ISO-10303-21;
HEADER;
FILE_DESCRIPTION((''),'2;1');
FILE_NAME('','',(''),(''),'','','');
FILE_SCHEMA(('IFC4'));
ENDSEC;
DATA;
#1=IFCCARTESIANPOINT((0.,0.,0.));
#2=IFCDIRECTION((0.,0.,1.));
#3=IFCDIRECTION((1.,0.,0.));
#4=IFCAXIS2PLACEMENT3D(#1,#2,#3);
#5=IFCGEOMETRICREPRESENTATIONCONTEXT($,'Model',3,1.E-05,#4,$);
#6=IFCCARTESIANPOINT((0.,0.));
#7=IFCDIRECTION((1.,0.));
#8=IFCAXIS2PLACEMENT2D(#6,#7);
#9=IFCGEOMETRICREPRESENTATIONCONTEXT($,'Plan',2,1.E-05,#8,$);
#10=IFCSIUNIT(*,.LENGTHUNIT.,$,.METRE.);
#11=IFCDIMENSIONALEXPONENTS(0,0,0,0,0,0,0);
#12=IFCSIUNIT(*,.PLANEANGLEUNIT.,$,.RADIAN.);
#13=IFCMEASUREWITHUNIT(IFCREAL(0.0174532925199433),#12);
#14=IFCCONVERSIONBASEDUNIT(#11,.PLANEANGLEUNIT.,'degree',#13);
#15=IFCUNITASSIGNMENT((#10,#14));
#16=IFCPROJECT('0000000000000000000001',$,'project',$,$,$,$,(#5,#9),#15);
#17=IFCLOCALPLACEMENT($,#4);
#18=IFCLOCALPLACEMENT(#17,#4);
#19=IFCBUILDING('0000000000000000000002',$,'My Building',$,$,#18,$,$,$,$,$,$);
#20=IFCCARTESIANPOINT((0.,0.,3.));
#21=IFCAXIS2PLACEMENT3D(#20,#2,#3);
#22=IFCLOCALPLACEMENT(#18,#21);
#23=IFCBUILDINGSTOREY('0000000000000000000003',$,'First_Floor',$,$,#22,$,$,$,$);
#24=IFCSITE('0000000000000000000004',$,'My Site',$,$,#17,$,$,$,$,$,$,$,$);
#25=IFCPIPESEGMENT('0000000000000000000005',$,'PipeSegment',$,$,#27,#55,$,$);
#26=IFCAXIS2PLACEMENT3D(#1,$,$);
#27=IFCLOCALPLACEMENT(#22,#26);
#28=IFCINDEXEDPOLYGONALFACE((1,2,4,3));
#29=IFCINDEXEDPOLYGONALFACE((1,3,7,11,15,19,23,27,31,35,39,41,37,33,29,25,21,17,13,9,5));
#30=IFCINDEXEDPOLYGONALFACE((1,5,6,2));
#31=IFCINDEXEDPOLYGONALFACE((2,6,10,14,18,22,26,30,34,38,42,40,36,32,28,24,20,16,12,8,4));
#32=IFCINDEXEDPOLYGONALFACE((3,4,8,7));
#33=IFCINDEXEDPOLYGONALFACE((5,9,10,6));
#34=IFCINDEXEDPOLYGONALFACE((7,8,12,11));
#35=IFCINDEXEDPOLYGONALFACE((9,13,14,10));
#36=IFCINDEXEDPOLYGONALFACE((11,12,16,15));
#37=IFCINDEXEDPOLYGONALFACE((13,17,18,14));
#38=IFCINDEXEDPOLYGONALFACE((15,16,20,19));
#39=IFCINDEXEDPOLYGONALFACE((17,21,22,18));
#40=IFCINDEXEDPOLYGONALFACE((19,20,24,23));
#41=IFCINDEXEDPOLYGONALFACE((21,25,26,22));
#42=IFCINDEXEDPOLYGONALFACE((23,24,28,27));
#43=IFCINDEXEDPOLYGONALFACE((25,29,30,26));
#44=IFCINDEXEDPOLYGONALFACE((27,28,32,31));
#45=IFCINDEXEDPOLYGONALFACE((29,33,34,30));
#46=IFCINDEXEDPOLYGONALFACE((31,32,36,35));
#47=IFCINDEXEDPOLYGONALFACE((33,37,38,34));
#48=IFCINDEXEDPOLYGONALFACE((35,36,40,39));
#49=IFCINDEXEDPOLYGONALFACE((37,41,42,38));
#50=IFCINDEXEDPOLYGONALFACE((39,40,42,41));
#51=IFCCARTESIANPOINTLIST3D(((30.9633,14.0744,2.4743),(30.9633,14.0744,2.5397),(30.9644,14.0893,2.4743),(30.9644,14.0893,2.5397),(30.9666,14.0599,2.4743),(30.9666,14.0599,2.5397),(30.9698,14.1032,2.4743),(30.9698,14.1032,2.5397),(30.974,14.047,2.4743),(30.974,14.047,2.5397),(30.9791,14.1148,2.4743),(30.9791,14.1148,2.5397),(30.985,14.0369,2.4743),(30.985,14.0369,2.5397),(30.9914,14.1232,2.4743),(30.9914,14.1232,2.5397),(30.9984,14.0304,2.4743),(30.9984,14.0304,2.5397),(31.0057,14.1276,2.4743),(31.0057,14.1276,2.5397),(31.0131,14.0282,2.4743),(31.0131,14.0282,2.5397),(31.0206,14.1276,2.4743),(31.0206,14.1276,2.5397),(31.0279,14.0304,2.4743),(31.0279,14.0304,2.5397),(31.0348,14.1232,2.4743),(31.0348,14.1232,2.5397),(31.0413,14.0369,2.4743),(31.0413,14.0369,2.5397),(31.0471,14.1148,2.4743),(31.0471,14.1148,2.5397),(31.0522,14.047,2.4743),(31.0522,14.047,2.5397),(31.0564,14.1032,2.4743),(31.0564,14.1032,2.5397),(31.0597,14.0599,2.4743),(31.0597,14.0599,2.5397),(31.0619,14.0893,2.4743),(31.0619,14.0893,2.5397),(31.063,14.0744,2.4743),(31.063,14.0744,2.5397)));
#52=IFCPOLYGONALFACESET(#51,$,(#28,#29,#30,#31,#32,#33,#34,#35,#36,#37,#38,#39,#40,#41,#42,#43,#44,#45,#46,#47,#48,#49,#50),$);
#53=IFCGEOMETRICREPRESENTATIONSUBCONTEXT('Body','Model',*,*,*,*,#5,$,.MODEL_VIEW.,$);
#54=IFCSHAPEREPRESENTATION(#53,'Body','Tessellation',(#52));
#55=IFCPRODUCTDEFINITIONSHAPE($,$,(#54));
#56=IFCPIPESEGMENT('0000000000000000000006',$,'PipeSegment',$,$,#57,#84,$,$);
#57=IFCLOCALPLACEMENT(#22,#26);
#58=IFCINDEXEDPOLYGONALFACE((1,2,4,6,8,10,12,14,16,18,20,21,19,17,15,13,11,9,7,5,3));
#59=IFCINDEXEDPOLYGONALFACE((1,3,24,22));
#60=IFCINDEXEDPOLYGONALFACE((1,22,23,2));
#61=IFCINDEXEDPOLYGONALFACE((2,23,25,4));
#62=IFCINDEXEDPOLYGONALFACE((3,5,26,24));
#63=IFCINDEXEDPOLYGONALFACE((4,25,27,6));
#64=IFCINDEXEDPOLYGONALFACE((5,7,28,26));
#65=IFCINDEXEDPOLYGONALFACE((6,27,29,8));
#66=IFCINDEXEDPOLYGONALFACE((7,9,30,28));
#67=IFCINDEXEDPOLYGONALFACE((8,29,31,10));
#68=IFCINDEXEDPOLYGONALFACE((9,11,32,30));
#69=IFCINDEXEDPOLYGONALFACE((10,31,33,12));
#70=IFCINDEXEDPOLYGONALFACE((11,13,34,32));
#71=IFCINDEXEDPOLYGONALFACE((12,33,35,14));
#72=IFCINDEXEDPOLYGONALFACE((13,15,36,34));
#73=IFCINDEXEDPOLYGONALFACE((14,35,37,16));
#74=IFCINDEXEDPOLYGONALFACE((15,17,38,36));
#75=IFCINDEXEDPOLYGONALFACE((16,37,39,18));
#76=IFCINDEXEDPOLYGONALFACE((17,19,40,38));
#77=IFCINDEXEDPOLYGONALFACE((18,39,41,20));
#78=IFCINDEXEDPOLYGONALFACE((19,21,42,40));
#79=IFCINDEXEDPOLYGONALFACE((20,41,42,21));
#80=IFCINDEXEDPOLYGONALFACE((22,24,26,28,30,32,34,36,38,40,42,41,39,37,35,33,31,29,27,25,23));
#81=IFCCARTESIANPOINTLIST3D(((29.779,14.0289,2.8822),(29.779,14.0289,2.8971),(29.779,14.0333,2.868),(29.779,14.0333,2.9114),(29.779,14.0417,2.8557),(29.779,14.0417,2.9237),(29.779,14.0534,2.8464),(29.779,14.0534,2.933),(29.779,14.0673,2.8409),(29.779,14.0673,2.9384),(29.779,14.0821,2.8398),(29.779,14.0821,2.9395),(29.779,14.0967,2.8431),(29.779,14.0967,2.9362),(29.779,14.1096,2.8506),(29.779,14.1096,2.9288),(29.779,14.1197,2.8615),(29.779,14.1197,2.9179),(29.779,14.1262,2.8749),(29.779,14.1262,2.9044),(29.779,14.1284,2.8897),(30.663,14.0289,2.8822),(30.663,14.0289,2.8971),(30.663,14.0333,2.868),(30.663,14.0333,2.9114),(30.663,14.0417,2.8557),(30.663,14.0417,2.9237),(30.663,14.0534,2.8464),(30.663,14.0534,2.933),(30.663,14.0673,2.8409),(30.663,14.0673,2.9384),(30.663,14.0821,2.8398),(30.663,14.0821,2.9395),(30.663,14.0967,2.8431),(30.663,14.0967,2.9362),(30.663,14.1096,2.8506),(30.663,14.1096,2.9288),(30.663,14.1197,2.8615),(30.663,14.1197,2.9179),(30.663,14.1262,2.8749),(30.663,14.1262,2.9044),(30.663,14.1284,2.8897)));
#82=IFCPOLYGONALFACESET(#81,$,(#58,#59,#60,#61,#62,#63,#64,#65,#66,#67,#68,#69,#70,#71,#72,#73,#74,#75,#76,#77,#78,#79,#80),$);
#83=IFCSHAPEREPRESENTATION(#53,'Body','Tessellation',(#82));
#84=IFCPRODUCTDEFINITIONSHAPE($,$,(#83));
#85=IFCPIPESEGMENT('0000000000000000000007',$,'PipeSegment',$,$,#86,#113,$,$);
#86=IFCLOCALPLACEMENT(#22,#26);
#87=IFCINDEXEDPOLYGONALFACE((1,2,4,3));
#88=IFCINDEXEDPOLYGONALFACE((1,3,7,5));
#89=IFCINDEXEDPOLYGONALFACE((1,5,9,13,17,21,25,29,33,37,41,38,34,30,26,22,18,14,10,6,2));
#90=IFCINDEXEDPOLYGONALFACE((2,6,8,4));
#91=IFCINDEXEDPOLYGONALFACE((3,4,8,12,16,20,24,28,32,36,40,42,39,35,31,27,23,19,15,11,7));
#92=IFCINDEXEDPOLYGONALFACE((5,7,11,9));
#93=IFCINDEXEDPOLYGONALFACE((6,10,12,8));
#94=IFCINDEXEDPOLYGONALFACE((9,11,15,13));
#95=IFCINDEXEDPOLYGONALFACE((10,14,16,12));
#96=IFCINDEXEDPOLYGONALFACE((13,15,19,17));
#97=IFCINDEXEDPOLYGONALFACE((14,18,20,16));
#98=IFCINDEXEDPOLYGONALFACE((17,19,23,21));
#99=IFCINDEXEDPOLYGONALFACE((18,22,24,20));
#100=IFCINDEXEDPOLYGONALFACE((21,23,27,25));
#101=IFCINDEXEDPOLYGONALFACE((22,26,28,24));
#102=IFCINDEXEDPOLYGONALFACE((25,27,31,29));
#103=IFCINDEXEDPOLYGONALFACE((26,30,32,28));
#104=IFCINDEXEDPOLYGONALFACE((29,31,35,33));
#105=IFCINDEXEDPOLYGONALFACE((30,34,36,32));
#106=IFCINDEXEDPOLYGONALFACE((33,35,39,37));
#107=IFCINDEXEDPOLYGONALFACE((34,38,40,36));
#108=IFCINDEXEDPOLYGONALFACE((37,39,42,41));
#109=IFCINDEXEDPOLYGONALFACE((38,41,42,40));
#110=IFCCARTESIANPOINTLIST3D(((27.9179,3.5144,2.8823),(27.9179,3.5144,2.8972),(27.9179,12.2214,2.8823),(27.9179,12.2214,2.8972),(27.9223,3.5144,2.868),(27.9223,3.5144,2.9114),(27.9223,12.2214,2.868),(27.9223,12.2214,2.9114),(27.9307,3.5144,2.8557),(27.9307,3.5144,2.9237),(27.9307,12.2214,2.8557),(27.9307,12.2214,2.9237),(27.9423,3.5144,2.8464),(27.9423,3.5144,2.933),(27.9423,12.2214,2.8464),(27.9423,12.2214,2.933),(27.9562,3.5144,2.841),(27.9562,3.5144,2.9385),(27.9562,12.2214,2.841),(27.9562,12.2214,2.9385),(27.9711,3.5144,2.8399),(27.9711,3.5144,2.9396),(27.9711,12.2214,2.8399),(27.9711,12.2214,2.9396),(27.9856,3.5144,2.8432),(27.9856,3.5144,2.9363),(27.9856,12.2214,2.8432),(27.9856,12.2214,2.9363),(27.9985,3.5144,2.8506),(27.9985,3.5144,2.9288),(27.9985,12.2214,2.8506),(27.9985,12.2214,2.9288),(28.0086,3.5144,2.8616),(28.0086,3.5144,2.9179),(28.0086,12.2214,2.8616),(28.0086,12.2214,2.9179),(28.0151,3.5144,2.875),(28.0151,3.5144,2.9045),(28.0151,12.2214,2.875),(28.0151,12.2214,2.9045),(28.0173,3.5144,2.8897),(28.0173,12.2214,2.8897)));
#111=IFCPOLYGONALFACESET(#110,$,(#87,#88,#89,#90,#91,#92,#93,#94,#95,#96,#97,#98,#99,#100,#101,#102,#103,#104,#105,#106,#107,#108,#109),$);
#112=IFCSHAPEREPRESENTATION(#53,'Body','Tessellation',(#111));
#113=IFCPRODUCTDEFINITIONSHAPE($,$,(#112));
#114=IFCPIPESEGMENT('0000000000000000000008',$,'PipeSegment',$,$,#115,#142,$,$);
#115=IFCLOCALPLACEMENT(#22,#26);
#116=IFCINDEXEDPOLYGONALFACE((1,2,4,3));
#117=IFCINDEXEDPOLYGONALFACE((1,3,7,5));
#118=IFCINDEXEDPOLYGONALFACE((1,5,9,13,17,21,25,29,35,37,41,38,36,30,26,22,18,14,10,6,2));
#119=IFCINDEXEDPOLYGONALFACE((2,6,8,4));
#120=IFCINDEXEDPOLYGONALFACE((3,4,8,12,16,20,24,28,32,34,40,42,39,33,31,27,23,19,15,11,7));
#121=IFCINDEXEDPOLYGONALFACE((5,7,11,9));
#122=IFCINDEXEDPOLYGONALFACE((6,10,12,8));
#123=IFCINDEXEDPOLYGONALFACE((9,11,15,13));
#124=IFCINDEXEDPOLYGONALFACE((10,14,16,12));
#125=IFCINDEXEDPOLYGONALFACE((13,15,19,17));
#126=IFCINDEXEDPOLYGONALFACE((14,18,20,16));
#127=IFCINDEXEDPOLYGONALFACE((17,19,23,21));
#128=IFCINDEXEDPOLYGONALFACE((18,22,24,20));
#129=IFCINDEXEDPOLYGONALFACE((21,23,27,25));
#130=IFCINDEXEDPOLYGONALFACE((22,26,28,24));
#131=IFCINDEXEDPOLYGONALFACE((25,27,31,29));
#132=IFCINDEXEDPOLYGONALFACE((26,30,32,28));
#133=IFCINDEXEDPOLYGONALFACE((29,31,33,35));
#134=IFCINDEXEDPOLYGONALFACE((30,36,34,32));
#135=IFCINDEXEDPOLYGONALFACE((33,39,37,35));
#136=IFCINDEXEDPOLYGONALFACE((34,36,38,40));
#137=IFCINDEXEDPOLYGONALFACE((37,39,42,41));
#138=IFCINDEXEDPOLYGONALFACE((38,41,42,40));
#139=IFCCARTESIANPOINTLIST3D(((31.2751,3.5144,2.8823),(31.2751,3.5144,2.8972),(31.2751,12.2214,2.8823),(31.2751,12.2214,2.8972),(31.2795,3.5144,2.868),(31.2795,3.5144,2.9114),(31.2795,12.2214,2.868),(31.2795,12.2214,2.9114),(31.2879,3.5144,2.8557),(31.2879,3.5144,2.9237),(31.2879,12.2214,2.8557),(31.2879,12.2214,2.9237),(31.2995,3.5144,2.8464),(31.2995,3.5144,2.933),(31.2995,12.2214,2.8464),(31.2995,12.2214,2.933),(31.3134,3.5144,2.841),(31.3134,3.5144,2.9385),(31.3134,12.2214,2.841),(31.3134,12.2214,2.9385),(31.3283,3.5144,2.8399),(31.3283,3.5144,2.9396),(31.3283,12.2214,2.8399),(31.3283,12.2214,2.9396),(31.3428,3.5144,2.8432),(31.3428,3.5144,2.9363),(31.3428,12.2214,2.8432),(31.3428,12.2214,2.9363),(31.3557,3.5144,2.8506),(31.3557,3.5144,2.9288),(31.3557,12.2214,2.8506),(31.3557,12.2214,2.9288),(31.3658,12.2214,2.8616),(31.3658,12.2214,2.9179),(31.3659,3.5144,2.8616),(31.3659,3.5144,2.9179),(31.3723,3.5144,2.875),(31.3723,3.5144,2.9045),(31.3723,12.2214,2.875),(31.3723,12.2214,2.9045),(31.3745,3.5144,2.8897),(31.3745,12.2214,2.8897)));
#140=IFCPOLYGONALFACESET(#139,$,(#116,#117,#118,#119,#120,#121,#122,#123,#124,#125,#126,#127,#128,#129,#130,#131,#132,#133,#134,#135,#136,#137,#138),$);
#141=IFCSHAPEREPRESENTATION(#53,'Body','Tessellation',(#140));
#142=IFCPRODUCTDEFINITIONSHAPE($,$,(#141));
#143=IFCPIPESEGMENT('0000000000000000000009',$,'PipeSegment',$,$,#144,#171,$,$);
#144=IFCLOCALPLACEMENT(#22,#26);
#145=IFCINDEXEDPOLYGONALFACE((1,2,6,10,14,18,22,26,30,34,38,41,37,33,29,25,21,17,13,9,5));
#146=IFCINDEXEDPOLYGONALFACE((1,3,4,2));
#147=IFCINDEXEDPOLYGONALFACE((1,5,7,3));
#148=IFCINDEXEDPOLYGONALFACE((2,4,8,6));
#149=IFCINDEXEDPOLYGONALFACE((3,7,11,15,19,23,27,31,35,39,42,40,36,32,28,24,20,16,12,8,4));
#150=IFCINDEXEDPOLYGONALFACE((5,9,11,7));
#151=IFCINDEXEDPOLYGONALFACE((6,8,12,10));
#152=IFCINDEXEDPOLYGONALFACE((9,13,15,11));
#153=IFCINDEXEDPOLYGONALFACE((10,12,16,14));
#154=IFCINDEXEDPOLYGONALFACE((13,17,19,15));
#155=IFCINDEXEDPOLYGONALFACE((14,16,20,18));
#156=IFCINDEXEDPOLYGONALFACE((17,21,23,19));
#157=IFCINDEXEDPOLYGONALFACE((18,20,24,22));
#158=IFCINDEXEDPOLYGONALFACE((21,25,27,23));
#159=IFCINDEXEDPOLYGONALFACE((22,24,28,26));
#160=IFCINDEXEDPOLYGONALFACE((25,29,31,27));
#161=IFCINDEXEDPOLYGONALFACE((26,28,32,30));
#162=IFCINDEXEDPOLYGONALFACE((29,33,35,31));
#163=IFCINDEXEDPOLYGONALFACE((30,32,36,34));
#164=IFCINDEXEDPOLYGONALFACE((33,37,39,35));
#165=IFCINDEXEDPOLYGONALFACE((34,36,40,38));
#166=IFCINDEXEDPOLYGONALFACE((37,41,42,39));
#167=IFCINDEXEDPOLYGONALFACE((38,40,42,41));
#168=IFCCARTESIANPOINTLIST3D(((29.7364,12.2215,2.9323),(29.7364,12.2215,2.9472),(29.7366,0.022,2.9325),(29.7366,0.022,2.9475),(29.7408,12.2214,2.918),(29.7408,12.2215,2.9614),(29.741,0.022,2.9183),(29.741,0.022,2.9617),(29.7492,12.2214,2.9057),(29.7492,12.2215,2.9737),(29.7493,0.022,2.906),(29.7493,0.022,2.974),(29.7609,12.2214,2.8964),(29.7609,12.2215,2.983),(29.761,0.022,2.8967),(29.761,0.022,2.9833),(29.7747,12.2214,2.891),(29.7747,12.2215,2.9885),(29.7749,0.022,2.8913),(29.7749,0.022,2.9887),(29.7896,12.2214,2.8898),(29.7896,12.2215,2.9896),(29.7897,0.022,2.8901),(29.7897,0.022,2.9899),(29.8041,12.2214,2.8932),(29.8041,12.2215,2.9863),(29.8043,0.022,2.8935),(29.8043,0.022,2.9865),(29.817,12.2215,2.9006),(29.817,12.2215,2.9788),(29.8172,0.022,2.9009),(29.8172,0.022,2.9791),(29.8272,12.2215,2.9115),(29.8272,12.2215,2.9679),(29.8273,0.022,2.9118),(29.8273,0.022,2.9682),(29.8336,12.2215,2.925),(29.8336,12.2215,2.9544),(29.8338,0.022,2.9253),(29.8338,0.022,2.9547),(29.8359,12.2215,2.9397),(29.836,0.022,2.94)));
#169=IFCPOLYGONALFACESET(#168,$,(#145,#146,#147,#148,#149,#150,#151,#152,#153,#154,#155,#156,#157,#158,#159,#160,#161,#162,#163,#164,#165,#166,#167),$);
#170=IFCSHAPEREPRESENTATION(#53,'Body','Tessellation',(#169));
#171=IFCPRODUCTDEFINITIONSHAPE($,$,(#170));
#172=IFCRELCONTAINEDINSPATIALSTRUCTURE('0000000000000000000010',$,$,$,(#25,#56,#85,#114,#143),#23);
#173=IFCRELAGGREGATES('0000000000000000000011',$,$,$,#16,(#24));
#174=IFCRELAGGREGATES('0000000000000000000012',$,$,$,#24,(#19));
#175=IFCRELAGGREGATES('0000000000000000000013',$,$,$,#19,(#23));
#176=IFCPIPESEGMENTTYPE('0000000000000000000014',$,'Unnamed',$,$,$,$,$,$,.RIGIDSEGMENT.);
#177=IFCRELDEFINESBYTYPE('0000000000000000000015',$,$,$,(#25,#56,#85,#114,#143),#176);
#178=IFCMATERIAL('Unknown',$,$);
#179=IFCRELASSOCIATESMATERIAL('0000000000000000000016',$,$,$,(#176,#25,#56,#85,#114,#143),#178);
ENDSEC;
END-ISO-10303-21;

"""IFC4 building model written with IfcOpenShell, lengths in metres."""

from ifc_helpers import new_model, entity, si_unit, converted_unit, frame, origin_with_axes, origin_2d_with_axis, place, context, subcontext, project, spatial, circle, extrude, material, material_profile, profile_set, profile_usage, type_object, element, save


model = new_model("IFC4")

# Units and contexts
model_context = context("Model", 3, precision=1e-05, world=origin_with_axes())
plan_context = context("Plan", 2, precision=1e-05, world=origin_2d_with_axis())
body_context_1 = subcontext(model_context, "Body", "Model", "MODEL_VIEW")
ifc_project = project(units=[si_unit("LENGTHUNIT", "METRE"), converted_unit("PLANEANGLEUNIT", "degree", entity("IfcReal", 0.0174532925199433), si_unit("PLANEANGLEUNIT", "RADIAN"), dimensions=[0, 0, 0, 0, 0, 0, 0])], contexts=[model_context, plan_context])

# Site, building, storey
site_placement = place(None, origin_with_axes())
site = spatial("IfcSite", under=ifc_project, at=site_placement, Name="My Site")
building_placement = place(site_placement, origin_with_axes())
building = spatial("IfcBuilding", under=site, at=building_placement, Name="My Building")
storey_placement = place(building_placement, frame((0.0, 0.0, 3.0), z_axis=(0.0, 0.0, 1.0), x_axis=(1.0, 0.0, 0.0)))
storey = spatial("IfcBuildingStorey", under=building, at=storey_placement, Name="First_Floor")

# Shared definitions
ifc_material = material(Name="Unknown")

# Pipe segments
ifc_material_profile_1 = material_profile(ifc_material, circle(Radius=0.05))
ifc_profile_set_1 = profile_set([ifc_material_profile_1])
pipe_segment_type = type_object("IfcPipeSegmentType", Name="Unnamed", PredefinedType="RIGIDSEGMENT", material=ifc_profile_set_1)
ifc_profile_usage_1 = profile_usage(ifc_profile_set_1, cardinal=5)
pipe_segment_1_placement = place(storey_placement, frame((31.0131, 14.0782, 2.4743), z_axis=(0.0, 0.0, 1.0), x_axis=(0.0, -1.0, 0.0)))
element("IfcPipeSegment", 1, at=pipe_segment_1_placement, inside=storey, type_object=pipe_segment_type, material=ifc_profile_usage_1, Name="PipeSegment", context=body_context_1, shape_type="SweptSolid", body=[
    extrude(circle(Radius=0.05), origin_with_axes(), (0.0, 0.0, 1.0), 0.0654),
])
ifc_profile_usage_2 = profile_usage(ifc_profile_set_1, cardinal=5)
pipe_segment_2_placement = place(storey_placement, frame((29.779, 14.0784, 2.8897), z_axis=(1.0, 0.0, 0.0), x_axis=(0.0, 1.0, 0.0)))
element("IfcPipeSegment", 2, at=pipe_segment_2_placement, inside=storey, type_object=pipe_segment_type, material=ifc_profile_usage_2, Name="PipeSegment", context=body_context_1, shape_type="SweptSolid", body=[
    extrude(circle(Radius=0.05), origin_with_axes(), (0.0, 0.0, 1.0), 0.884),
])
ifc_profile_usage_3 = profile_usage(ifc_profile_set_1, cardinal=5)
pipe_segment_3_placement = place(storey_placement, frame((27.9673, 12.2214, 2.8897), z_axis=(0.0, -1.0, 0.0), x_axis=(1.0, 0.0, 0.0)))
element("IfcPipeSegment", 3, at=pipe_segment_3_placement, inside=storey, type_object=pipe_segment_type, material=ifc_profile_usage_3, Name="PipeSegment", context=body_context_1, shape_type="SweptSolid", body=[
    extrude(circle(Radius=0.05), origin_with_axes(), (0.0, 0.0, 1.0), 8.707),
])
ifc_profile_usage_4 = profile_usage(ifc_profile_set_1, cardinal=5)
pipe_segment_4_placement = place(storey_placement, frame((31.3245, 12.2214, 2.8897), z_axis=(0.0, -1.0, 0.0), x_axis=(1.0, 0.0, 0.0)))
element("IfcPipeSegment", 4, at=pipe_segment_4_placement, inside=storey, type_object=pipe_segment_type, material=ifc_profile_usage_4, Name="PipeSegment", context=body_context_1, shape_type="SweptSolid", body=[
    extrude(circle(Radius=0.05), origin_with_axes(), (0.0, 0.0, 1.0), 8.707),
])
ifc_profile_usage_5 = profile_usage(ifc_profile_set_1, cardinal=5)
pipe_segment_5_placement = place(storey_placement, frame((29.7859, 12.2215, 2.9397), z_axis=(0.000011, -1.0, 0.000024), x_axis=(1.0, 0.000011, 0.0)))
element("IfcPipeSegment", 5, at=pipe_segment_5_placement, inside=storey, type_object=pipe_segment_type, material=ifc_profile_usage_5, Name="PipeSegment", context=body_context_1, shape_type="SweptSolid", body=[
    extrude(circle(Radius=0.05), origin_with_axes(), (0.0, 0.0, 1.0), 12.1995),
])

save(model, "model.ifc")
